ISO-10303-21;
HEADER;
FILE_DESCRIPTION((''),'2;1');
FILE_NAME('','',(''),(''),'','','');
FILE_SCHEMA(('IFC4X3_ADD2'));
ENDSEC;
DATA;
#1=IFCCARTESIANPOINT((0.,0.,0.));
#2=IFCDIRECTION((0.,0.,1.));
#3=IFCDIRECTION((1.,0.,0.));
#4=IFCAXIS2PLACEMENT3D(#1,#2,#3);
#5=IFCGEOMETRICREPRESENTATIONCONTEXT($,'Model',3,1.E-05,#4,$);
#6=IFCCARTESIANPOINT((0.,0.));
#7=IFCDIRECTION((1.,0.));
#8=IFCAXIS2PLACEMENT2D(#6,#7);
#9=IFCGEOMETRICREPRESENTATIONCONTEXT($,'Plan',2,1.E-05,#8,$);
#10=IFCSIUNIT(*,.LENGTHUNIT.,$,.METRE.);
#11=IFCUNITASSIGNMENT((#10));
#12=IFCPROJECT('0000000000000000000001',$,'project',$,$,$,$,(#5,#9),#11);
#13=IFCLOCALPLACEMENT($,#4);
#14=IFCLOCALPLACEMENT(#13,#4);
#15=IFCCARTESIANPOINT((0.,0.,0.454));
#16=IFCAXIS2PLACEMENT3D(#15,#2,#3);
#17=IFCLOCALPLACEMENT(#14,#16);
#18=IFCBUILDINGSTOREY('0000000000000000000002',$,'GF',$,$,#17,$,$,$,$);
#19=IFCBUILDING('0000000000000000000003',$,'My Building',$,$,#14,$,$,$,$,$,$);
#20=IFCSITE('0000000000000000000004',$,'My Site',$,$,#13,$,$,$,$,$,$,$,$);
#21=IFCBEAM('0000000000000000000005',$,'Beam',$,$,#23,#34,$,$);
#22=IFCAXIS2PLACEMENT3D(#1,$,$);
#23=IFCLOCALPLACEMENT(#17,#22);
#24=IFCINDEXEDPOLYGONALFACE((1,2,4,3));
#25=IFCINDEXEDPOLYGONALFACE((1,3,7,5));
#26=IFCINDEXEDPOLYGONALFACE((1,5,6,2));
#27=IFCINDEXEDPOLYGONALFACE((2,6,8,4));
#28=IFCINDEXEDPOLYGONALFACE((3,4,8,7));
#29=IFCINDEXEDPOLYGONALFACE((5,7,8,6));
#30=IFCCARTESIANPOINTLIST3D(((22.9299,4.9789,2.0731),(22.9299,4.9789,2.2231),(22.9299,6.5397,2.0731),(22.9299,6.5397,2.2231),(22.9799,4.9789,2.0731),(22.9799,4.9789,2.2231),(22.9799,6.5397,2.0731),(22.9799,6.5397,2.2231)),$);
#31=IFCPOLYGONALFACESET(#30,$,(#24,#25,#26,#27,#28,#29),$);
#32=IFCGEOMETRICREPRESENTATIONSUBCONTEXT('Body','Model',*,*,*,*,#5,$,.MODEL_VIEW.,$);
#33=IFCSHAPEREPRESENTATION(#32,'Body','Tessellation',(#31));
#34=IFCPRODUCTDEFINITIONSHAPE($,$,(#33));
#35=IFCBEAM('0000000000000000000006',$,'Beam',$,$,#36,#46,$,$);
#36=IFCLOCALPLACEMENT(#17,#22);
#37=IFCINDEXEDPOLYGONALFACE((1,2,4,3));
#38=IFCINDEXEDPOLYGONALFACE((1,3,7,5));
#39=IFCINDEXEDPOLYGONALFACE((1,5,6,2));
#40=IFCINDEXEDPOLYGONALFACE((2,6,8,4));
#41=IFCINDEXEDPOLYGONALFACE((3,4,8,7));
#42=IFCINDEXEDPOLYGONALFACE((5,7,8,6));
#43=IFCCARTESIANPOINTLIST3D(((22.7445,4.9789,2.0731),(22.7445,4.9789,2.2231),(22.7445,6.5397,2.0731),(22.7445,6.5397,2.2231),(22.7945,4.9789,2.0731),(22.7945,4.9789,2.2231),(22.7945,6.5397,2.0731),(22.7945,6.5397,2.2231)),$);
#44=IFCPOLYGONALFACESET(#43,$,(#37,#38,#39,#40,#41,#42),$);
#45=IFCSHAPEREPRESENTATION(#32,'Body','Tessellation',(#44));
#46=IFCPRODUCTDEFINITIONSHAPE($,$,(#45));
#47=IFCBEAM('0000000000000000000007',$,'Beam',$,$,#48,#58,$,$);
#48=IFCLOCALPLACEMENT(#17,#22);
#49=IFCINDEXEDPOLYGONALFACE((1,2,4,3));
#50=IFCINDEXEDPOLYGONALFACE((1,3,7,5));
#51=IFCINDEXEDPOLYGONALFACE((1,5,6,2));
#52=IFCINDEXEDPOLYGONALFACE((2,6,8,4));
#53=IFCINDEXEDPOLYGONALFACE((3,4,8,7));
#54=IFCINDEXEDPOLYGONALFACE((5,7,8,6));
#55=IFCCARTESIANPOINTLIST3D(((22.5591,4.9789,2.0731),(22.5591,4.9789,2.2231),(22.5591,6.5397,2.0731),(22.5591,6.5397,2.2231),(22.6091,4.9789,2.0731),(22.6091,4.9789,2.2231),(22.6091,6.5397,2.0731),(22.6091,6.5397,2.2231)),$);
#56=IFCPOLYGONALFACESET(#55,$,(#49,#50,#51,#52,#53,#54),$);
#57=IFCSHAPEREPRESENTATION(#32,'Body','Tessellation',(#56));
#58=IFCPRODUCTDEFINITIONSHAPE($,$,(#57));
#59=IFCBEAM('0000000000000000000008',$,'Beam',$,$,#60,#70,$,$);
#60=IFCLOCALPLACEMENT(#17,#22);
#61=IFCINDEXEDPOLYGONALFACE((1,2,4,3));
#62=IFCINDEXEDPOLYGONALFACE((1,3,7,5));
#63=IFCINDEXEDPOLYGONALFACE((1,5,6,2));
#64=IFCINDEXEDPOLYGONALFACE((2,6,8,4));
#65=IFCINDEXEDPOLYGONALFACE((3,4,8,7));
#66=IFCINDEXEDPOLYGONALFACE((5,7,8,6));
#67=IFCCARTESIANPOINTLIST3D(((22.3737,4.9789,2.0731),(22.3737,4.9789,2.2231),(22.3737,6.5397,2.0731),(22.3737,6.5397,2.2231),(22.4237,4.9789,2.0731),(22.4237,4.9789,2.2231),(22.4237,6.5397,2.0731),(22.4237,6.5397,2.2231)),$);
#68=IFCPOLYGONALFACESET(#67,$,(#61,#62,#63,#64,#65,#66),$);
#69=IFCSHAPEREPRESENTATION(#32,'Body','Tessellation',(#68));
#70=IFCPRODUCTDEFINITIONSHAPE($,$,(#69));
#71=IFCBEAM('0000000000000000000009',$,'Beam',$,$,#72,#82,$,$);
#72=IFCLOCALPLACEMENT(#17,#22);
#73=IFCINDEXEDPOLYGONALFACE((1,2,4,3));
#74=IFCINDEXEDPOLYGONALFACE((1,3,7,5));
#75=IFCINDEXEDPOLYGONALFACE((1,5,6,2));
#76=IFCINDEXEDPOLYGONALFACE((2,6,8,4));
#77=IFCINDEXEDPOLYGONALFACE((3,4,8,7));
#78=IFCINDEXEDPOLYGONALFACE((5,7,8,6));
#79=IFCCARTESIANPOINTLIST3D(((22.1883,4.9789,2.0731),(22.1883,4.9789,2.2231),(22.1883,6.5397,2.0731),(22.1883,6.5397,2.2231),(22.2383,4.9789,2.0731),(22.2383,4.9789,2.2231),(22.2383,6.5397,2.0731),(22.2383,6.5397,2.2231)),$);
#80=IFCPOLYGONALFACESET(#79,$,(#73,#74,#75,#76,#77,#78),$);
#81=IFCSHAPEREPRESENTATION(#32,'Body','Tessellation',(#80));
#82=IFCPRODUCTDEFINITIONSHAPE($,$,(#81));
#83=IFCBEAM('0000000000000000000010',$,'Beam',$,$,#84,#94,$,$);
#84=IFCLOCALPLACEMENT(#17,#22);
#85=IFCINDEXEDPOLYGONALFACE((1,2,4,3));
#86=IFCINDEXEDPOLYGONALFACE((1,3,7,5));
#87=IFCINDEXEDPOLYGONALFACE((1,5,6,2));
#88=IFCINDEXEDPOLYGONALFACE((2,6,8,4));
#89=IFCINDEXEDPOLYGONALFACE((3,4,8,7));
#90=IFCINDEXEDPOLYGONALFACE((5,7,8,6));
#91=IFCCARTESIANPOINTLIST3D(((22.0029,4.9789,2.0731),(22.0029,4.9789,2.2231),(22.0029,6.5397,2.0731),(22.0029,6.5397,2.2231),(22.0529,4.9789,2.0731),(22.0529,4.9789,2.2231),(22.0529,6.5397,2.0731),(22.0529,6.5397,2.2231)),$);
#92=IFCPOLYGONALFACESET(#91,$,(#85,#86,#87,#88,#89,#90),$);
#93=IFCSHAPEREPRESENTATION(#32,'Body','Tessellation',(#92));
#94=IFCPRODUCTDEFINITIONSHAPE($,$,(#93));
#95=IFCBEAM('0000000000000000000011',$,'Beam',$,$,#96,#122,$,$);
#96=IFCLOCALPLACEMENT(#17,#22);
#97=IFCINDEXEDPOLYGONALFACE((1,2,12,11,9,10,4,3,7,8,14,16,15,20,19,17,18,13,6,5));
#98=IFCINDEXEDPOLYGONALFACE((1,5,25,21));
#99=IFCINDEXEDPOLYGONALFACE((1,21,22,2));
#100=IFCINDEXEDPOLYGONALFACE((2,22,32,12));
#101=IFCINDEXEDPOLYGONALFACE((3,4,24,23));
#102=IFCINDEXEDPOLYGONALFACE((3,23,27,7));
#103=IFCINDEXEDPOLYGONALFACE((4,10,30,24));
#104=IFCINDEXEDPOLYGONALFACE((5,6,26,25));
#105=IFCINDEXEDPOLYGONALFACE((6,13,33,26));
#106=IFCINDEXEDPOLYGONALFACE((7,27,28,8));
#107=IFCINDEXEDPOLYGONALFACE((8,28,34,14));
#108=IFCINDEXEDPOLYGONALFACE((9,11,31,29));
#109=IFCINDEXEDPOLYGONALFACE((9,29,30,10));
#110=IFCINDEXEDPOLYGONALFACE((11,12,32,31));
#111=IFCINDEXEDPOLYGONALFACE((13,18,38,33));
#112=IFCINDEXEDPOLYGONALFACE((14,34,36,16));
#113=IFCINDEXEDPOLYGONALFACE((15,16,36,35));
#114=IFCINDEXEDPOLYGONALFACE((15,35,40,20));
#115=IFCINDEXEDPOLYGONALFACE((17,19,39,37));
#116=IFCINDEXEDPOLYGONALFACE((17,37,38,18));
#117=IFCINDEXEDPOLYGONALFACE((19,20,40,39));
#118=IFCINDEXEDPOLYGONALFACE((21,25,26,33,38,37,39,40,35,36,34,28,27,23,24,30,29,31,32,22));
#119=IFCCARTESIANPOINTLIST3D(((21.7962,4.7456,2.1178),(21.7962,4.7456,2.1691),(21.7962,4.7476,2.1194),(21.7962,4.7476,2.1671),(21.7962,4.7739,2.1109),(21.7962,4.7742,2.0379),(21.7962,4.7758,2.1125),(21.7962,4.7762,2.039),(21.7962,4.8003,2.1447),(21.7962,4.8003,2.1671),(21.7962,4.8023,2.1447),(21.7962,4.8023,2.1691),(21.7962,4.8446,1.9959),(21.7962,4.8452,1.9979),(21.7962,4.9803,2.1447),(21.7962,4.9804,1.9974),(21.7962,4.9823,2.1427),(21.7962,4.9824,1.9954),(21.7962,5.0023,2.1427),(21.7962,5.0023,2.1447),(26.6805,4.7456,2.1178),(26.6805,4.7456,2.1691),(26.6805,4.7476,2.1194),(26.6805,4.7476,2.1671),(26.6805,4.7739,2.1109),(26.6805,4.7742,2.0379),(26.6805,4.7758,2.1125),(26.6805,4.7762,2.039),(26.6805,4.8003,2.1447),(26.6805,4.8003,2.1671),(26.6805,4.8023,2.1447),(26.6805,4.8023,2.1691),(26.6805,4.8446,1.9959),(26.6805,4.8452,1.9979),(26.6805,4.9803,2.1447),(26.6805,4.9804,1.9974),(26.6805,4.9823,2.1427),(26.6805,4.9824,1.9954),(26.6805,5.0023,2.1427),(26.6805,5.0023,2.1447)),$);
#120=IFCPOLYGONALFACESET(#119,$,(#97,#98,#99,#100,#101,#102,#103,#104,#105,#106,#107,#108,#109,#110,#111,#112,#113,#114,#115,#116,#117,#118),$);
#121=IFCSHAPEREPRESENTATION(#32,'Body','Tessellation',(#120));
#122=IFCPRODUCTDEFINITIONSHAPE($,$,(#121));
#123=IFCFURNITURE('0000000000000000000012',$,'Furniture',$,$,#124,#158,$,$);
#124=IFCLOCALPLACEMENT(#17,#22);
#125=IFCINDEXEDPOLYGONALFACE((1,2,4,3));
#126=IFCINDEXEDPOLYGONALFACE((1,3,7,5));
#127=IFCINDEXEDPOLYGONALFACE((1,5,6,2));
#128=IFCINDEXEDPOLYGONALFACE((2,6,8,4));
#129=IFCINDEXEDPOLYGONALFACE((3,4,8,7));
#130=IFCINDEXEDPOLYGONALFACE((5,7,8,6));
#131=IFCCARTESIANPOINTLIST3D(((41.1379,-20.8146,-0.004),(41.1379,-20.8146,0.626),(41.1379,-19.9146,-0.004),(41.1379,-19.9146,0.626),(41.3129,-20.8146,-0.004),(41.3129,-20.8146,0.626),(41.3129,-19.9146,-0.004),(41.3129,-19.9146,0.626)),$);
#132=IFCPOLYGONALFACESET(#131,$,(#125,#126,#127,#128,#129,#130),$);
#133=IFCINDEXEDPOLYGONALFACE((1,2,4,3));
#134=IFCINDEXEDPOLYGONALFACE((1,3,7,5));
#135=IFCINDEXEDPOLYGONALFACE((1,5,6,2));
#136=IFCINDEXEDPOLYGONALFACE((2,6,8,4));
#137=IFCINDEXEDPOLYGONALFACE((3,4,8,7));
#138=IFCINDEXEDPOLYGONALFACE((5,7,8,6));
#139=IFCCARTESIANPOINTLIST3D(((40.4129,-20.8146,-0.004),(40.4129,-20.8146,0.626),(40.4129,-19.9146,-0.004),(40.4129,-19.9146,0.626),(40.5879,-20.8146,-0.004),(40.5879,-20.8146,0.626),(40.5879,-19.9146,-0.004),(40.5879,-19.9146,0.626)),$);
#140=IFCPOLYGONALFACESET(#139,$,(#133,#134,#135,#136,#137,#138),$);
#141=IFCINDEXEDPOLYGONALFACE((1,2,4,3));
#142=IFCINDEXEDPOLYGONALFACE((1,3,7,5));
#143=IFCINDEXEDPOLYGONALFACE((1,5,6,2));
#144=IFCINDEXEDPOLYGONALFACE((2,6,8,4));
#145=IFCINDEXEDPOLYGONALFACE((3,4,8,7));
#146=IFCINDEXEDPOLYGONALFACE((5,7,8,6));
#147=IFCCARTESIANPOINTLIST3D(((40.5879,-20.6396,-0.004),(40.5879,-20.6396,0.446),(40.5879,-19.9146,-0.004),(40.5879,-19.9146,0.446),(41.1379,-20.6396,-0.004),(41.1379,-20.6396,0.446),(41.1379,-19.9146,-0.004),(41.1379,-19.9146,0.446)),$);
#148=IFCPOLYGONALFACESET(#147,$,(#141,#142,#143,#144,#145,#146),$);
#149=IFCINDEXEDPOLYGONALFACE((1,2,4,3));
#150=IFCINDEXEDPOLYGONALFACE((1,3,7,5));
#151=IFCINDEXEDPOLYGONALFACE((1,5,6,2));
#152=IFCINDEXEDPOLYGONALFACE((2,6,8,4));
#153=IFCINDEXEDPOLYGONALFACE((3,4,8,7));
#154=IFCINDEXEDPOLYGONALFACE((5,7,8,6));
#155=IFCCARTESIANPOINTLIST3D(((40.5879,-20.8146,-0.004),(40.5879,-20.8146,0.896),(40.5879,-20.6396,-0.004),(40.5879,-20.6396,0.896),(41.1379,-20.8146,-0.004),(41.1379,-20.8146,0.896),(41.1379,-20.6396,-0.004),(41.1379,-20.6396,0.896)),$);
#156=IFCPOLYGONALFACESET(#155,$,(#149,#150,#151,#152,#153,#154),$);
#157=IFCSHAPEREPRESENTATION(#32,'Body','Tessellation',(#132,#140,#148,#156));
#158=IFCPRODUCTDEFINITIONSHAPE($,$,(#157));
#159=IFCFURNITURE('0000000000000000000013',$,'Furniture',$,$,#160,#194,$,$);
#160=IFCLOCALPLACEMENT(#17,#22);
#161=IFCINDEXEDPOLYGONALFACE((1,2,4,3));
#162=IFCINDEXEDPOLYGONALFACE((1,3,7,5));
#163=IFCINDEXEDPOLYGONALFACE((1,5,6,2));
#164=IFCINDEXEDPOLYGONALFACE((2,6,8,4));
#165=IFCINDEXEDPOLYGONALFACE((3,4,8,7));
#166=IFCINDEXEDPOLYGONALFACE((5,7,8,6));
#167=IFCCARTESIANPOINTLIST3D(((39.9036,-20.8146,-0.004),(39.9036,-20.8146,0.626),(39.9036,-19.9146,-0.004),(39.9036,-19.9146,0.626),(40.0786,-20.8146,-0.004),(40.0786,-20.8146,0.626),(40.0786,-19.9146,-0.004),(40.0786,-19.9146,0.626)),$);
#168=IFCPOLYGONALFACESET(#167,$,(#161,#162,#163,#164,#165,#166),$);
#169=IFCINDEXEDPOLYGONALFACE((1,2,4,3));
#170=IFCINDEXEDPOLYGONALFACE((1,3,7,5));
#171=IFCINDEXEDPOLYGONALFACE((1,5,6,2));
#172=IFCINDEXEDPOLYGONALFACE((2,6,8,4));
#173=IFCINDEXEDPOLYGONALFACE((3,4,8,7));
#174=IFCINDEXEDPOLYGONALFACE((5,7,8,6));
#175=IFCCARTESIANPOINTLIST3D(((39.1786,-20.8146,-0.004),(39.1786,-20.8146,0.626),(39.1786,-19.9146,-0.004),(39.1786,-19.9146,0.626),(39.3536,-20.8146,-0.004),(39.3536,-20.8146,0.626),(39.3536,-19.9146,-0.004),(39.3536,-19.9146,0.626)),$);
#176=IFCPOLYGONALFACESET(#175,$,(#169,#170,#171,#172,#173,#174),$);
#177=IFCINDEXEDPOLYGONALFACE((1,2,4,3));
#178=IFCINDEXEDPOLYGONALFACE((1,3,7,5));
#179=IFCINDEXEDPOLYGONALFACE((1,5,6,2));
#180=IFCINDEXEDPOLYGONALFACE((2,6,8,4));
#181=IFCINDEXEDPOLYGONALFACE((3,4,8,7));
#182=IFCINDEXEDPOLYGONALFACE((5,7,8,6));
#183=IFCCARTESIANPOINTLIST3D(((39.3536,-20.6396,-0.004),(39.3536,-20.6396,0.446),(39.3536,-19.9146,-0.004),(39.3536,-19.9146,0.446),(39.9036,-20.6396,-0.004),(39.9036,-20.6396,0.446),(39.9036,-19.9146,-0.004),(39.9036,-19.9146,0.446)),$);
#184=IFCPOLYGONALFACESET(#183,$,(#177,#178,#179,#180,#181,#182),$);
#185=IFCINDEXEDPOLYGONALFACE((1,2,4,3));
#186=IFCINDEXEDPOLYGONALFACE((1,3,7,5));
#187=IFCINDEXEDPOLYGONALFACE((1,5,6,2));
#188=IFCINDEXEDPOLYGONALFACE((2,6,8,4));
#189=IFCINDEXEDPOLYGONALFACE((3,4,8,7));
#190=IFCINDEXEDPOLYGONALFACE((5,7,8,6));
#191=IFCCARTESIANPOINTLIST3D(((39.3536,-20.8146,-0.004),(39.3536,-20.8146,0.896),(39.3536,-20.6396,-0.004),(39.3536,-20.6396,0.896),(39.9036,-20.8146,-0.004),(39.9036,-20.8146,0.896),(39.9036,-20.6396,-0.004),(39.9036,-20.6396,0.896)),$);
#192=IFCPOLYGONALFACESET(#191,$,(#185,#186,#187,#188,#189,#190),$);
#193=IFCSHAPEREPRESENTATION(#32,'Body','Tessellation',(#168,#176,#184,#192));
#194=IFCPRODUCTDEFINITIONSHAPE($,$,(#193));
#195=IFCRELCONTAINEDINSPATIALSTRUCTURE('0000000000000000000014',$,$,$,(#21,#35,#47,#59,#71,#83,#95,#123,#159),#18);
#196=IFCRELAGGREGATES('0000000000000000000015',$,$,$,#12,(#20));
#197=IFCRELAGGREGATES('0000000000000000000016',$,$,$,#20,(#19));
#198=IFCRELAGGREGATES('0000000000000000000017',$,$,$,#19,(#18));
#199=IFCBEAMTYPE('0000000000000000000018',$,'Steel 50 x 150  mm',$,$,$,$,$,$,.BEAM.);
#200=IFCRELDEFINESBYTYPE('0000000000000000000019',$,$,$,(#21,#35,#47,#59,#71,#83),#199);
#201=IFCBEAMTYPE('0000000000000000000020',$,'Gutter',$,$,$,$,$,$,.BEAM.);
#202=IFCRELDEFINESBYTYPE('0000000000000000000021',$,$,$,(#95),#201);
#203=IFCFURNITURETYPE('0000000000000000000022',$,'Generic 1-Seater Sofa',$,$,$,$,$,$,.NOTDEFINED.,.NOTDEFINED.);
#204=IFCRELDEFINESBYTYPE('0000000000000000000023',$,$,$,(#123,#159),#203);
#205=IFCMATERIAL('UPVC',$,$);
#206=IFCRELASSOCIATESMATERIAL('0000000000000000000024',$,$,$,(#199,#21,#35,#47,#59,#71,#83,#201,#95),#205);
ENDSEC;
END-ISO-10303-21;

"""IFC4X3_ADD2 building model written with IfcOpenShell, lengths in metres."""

from ifc_helpers import new_model, entity, si_unit, frame, origin_with_axes, origin_2d_with_axis, place, context, subcontext, project, spatial, line, indexed_curve, rectangle, outline, extrude, shape, source, transform, mapped, material, material_profile, profile_set, profile_usage, type_object, type_shapes, element, save


model = new_model("IFC4X3_ADD2")

# Units and contexts
model_context = context("Model", 3, precision=1e-05, world=origin_with_axes())
plan_context = context("Plan", 2, precision=1e-05, world=origin_2d_with_axis())
body_context_1 = subcontext(model_context, "Body", "Model", "MODEL_VIEW")
body_context_2 = subcontext(plan_context, "Body", "Plan", "PLAN_VIEW")
ifc_project = project(units=[si_unit("LENGTHUNIT", "METRE")], contexts=[model_context, plan_context])

# Site, building, storey
site_placement = place(None, origin_with_axes())
site = spatial("IfcSite", under=ifc_project, at=site_placement, Name="My Site")
building_placement = place(site_placement, origin_with_axes())
building = spatial("IfcBuilding", under=site, at=building_placement, Name="My Building")
storey_placement = place(building_placement, frame((0.0, 0.0, 0.454), z_axis=(0.0, 0.0, 1.0), x_axis=(1.0, 0.0, 0.0)))
storey = spatial("IfcBuildingStorey", under=building, at=storey_placement, Name="GF")

# Beams
ifc_material_1 = material(Name="UPVC")
ifc_material_profile_1 = material_profile(ifc_material_1, rectangle(XDim=0.05, YDim=0.15))
ifc_profile_set_1 = profile_set([ifc_material_profile_1])
beam_type_1 = type_object("IfcBeamType", Name="Steel 50 x 150  mm", PredefinedType="BEAM", material=ifc_profile_set_1)
ifc_profile_usage_1 = profile_usage(ifc_profile_set_1)
beam_1_placement = place(storey_placement, frame((22.9549, 6.5397, 2.1481), z_axis=(0.0, -1.0, 0.0), x_axis=(1.0, 0.0, 0.0)))
element("IfcBeam", 1, at=beam_1_placement, inside=storey, type_object=beam_type_1, material=ifc_profile_usage_1, Name="Beam", context=body_context_1, shape_type="SweptSolid", body=[
    extrude(rectangle(XDim=0.05, YDim=0.15), origin_with_axes(), (0.0, 0.0, 1.0), 1.5608),
])
ifc_profile_usage_2 = profile_usage(ifc_profile_set_1)
beam_2_placement = place(storey_placement, frame((22.7695, 6.5397, 2.1481), z_axis=(0.0, -1.0, 0.0), x_axis=(1.0, 0.0, 0.0)))
element("IfcBeam", 2, at=beam_2_placement, inside=storey, type_object=beam_type_1, material=ifc_profile_usage_2, Name="Beam", context=body_context_1, shape_type="SweptSolid", body=[
    extrude(rectangle(XDim=0.05, YDim=0.15), origin_with_axes(), (0.0, 0.0, 1.0), 1.5608),
])
ifc_profile_usage_3 = profile_usage(ifc_profile_set_1)
beam_3_placement = place(storey_placement, frame((22.5841, 6.5397, 2.1481), z_axis=(0.0, -1.0, 0.0), x_axis=(1.0, 0.0, 0.0)))
element("IfcBeam", 3, at=beam_3_placement, inside=storey, type_object=beam_type_1, material=ifc_profile_usage_3, Name="Beam", context=body_context_1, shape_type="SweptSolid", body=[
    extrude(rectangle(XDim=0.05, YDim=0.15), origin_with_axes(), (0.0, 0.0, 1.0), 1.5608),
])
ifc_profile_usage_4 = profile_usage(ifc_profile_set_1)
beam_4_placement = place(storey_placement, frame((22.3987, 6.5397, 2.1481), z_axis=(0.0, -1.0, 0.0), x_axis=(1.0, 0.0, 0.0)))
element("IfcBeam", 4, at=beam_4_placement, inside=storey, type_object=beam_type_1, material=ifc_profile_usage_4, Name="Beam", context=body_context_1, shape_type="SweptSolid", body=[
    extrude(rectangle(XDim=0.05, YDim=0.15), origin_with_axes(), (0.0, 0.0, 1.0), 1.5608),
])
ifc_profile_usage_5 = profile_usage(ifc_profile_set_1)
beam_5_placement = place(storey_placement, frame((22.2133, 6.5397, 2.1481), z_axis=(0.0, -1.0, 0.0), x_axis=(1.0, 0.0, 0.0)))
element("IfcBeam", 5, at=beam_5_placement, inside=storey, type_object=beam_type_1, material=ifc_profile_usage_5, Name="Beam", context=body_context_1, shape_type="SweptSolid", body=[
    extrude(rectangle(XDim=0.05, YDim=0.15), origin_with_axes(), (0.0, 0.0, 1.0), 1.5608),
])
ifc_profile_usage_6 = profile_usage(ifc_profile_set_1)
beam_6_placement = place(storey_placement, frame((22.0279, 6.5397, 2.1481), z_axis=(0.0, -1.0, 0.0), x_axis=(1.0, 0.0, 0.0)))
element("IfcBeam", 6, at=beam_6_placement, inside=storey, type_object=beam_type_1, material=ifc_profile_usage_6, Name="Beam", context=body_context_1, shape_type="SweptSolid", body=[
    extrude(rectangle(XDim=0.05, YDim=0.15), origin_with_axes(), (0.0, 0.0, 1.0), 1.5608),
])
ifc_material_profile_2 = material_profile(ifc_material_1, outline(indexed_curve([(0.0548, 0.1717), (0.002, 0.1717), (0.002, 0.124), (0.0303, 0.1171), (0.0307, 0.0436), (0.0996, 0.0025), (0.2349, 0.002), (0.2347, 0.1494), (0.2567, 0.1494), (0.2567, 0.1474), (0.2367, 0.1474), (0.2369, 0.0), (0.0991, 0.0005), (0.0287, 0.0425), (0.0283, 0.1155), (0.0, 0.1224), (0.0, 0.1737), (0.0568, 0.1737), (0.0568, 0.1494), (0.0548, 0.1494), (0.0548, 0.1717)])))
ifc_profile_set_2 = profile_set([ifc_material_profile_2])
ifc_profile_usage_7 = profile_usage(ifc_profile_set_2)
beam_type_2 = type_object("IfcBeamType", Name="Gutter", PredefinedType="BEAM", material=ifc_profile_set_2)
beam_7_placement = place(storey_placement, frame((21.7962, 4.7456, 1.9954), z_axis=(1.0, 0.0, 0.0), x_axis=(0.0, 1.0, 0.0)))
element("IfcBeam", 7, at=beam_7_placement, inside=storey, type_object=beam_type_2, material=ifc_profile_usage_7, Name="Beam", context=body_context_1, shape_type="SweptSolid", body=[
    extrude(outline(indexed_curve([(0.0548, 0.1717), (0.002, 0.1717), (0.002, 0.124), (0.0303, 0.1171), (0.0307, 0.0436), (0.0996, 0.0025), (0.2349, 0.002), (0.2347, 0.1494), (0.2567, 0.1494), (0.2567, 0.1474), (0.2367, 0.1474), (0.2369, 0.0), (0.0991, 0.0005), (0.0287, 0.0425), (0.0283, 0.1155), (0.0, 0.1224), (0.0, 0.1737), (0.0568, 0.1737), (0.0568, 0.1494), (0.0548, 0.1494), (0.0548, 0.1717)])), origin_with_axes(), (0.0, 0.0, 1.0), 4.8842),
])

# Furniture
furniture_type_1 = type_object("IfcFurnitureType", Name="Generic 1-Seater Sofa", AssemblyPlace="NOTDEFINED", PredefinedType="NOTDEFINED")
shared_shape_1 = source(origin_with_axes(), body_context_1, "Body", "SweptSolid", [
    extrude(outline(indexed_curve([(0.0, 0.0), (0.175, 0.0), (0.175, 0.9), (0.0, 0.9)], segments=[line(4, 1), line(1, 2), line(2, 3), line(3, 4)], self_intersect=False)), frame((-0.45, -0.9, 0.0), z_axis=(0.0, 0.0, 1.0), x_axis=(1.0, 0.0, 0.0)), (0.0, 0.0, 1.0), 0.63),
    extrude(outline(indexed_curve([(0.0, 0.0), (0.175, 0.0), (0.175, 0.9), (0.0, 0.9)], segments=[line(1, 2, 3, 4, 1)])), frame((0.275, -0.9, 0.0), z_axis=(0.0, 0.0, 1.0), x_axis=(1.0, 0.0, 0.0)), (0.0, 0.0, 1.0), 0.63),
    extrude(outline(indexed_curve([(0.175, 0.0), (0.725, 0.0), (0.725, 0.725), (0.175, 0.725)], segments=[line(1, 2, 3, 4, 1)])), frame((-0.45, -0.9, 0.0), z_axis=(0.0, 0.0, 1.0), x_axis=(1.0, 0.0, 0.0)), (0.0, 0.0, 1.0), 0.45),
    extrude(outline(indexed_curve([(0.175, 0.725), (0.725, 0.725), (0.725, 0.9), (0.175, 0.9)], segments=[line(1, 2, 3, 4, 1)])), frame((-0.45, -0.9, 0.0), z_axis=(0.0, 0.0, 1.0), x_axis=(1.0, 0.0, 0.0)), (0.0, 0.0, 1.0), 0.9),
])
shared_shape_2 = source(origin_with_axes(), body_context_2, "Body", "Annotation2D", [
    entity("IfcGeometricCurveSet", [entity("IfcIndexedPolyCurve", entity("IfcCartesianPointList2D", [[0.275, -0.175], [0.275, -0.9], [0.45, -0.9], [0.45, 0.0], [0.275, 0.0], [0.275, -0.9], [-0.275, -0.9], [-0.275, 0.0], [-0.275, -0.175], [0.275, -0.175], [0.275, 0.0], [-0.275, 0.0], [-0.45, 0.0], [-0.45, -0.9], [-0.275, -0.9], [-0.275, -0.175]]))]),
])
type_shapes(furniture_type_1, [shared_shape_1, shared_shape_2])
for number, where, z_axis, x_axis, name in (
    (8, (40.8629, -20.8146, -0.004), (0.0, 0.0, 1.0), (-1.0, 0.0, 0.0), "Furniture"),
    (9, (39.6286, -20.8146, -0.004), (0.0, 0.0, 1.0), (-1.0, 0.0, 0.0), "Furniture"),
):
    element("IfcFurniture", number, at=place(storey_placement, frame(where, z_axis=z_axis, x_axis=x_axis)), inside=storey, type_object=furniture_type_1, Name=name, shapes=[
        shape(body_context_1, "Body", "MappedRepresentation", [mapped(shared_shape_1, transform((0.0, 0.0, 0.0), x_axis=(1.0, 0.0, 0.0), y_axis=(0.0, 1.0, 0.0), z_axis=(0.0, 0.0, 1.0), scale=1.0))]),
        shape(body_context_2, "Body", "MappedRepresentation", [mapped(shared_shape_2, transform((0.0, 0.0, 0.0), x_axis=(1.0, 0.0, 0.0), y_axis=(0.0, 1.0, 0.0), z_axis=(0.0, 0.0, 1.0), scale=1.0))]),
    ])

save(model, "model.ifc")
